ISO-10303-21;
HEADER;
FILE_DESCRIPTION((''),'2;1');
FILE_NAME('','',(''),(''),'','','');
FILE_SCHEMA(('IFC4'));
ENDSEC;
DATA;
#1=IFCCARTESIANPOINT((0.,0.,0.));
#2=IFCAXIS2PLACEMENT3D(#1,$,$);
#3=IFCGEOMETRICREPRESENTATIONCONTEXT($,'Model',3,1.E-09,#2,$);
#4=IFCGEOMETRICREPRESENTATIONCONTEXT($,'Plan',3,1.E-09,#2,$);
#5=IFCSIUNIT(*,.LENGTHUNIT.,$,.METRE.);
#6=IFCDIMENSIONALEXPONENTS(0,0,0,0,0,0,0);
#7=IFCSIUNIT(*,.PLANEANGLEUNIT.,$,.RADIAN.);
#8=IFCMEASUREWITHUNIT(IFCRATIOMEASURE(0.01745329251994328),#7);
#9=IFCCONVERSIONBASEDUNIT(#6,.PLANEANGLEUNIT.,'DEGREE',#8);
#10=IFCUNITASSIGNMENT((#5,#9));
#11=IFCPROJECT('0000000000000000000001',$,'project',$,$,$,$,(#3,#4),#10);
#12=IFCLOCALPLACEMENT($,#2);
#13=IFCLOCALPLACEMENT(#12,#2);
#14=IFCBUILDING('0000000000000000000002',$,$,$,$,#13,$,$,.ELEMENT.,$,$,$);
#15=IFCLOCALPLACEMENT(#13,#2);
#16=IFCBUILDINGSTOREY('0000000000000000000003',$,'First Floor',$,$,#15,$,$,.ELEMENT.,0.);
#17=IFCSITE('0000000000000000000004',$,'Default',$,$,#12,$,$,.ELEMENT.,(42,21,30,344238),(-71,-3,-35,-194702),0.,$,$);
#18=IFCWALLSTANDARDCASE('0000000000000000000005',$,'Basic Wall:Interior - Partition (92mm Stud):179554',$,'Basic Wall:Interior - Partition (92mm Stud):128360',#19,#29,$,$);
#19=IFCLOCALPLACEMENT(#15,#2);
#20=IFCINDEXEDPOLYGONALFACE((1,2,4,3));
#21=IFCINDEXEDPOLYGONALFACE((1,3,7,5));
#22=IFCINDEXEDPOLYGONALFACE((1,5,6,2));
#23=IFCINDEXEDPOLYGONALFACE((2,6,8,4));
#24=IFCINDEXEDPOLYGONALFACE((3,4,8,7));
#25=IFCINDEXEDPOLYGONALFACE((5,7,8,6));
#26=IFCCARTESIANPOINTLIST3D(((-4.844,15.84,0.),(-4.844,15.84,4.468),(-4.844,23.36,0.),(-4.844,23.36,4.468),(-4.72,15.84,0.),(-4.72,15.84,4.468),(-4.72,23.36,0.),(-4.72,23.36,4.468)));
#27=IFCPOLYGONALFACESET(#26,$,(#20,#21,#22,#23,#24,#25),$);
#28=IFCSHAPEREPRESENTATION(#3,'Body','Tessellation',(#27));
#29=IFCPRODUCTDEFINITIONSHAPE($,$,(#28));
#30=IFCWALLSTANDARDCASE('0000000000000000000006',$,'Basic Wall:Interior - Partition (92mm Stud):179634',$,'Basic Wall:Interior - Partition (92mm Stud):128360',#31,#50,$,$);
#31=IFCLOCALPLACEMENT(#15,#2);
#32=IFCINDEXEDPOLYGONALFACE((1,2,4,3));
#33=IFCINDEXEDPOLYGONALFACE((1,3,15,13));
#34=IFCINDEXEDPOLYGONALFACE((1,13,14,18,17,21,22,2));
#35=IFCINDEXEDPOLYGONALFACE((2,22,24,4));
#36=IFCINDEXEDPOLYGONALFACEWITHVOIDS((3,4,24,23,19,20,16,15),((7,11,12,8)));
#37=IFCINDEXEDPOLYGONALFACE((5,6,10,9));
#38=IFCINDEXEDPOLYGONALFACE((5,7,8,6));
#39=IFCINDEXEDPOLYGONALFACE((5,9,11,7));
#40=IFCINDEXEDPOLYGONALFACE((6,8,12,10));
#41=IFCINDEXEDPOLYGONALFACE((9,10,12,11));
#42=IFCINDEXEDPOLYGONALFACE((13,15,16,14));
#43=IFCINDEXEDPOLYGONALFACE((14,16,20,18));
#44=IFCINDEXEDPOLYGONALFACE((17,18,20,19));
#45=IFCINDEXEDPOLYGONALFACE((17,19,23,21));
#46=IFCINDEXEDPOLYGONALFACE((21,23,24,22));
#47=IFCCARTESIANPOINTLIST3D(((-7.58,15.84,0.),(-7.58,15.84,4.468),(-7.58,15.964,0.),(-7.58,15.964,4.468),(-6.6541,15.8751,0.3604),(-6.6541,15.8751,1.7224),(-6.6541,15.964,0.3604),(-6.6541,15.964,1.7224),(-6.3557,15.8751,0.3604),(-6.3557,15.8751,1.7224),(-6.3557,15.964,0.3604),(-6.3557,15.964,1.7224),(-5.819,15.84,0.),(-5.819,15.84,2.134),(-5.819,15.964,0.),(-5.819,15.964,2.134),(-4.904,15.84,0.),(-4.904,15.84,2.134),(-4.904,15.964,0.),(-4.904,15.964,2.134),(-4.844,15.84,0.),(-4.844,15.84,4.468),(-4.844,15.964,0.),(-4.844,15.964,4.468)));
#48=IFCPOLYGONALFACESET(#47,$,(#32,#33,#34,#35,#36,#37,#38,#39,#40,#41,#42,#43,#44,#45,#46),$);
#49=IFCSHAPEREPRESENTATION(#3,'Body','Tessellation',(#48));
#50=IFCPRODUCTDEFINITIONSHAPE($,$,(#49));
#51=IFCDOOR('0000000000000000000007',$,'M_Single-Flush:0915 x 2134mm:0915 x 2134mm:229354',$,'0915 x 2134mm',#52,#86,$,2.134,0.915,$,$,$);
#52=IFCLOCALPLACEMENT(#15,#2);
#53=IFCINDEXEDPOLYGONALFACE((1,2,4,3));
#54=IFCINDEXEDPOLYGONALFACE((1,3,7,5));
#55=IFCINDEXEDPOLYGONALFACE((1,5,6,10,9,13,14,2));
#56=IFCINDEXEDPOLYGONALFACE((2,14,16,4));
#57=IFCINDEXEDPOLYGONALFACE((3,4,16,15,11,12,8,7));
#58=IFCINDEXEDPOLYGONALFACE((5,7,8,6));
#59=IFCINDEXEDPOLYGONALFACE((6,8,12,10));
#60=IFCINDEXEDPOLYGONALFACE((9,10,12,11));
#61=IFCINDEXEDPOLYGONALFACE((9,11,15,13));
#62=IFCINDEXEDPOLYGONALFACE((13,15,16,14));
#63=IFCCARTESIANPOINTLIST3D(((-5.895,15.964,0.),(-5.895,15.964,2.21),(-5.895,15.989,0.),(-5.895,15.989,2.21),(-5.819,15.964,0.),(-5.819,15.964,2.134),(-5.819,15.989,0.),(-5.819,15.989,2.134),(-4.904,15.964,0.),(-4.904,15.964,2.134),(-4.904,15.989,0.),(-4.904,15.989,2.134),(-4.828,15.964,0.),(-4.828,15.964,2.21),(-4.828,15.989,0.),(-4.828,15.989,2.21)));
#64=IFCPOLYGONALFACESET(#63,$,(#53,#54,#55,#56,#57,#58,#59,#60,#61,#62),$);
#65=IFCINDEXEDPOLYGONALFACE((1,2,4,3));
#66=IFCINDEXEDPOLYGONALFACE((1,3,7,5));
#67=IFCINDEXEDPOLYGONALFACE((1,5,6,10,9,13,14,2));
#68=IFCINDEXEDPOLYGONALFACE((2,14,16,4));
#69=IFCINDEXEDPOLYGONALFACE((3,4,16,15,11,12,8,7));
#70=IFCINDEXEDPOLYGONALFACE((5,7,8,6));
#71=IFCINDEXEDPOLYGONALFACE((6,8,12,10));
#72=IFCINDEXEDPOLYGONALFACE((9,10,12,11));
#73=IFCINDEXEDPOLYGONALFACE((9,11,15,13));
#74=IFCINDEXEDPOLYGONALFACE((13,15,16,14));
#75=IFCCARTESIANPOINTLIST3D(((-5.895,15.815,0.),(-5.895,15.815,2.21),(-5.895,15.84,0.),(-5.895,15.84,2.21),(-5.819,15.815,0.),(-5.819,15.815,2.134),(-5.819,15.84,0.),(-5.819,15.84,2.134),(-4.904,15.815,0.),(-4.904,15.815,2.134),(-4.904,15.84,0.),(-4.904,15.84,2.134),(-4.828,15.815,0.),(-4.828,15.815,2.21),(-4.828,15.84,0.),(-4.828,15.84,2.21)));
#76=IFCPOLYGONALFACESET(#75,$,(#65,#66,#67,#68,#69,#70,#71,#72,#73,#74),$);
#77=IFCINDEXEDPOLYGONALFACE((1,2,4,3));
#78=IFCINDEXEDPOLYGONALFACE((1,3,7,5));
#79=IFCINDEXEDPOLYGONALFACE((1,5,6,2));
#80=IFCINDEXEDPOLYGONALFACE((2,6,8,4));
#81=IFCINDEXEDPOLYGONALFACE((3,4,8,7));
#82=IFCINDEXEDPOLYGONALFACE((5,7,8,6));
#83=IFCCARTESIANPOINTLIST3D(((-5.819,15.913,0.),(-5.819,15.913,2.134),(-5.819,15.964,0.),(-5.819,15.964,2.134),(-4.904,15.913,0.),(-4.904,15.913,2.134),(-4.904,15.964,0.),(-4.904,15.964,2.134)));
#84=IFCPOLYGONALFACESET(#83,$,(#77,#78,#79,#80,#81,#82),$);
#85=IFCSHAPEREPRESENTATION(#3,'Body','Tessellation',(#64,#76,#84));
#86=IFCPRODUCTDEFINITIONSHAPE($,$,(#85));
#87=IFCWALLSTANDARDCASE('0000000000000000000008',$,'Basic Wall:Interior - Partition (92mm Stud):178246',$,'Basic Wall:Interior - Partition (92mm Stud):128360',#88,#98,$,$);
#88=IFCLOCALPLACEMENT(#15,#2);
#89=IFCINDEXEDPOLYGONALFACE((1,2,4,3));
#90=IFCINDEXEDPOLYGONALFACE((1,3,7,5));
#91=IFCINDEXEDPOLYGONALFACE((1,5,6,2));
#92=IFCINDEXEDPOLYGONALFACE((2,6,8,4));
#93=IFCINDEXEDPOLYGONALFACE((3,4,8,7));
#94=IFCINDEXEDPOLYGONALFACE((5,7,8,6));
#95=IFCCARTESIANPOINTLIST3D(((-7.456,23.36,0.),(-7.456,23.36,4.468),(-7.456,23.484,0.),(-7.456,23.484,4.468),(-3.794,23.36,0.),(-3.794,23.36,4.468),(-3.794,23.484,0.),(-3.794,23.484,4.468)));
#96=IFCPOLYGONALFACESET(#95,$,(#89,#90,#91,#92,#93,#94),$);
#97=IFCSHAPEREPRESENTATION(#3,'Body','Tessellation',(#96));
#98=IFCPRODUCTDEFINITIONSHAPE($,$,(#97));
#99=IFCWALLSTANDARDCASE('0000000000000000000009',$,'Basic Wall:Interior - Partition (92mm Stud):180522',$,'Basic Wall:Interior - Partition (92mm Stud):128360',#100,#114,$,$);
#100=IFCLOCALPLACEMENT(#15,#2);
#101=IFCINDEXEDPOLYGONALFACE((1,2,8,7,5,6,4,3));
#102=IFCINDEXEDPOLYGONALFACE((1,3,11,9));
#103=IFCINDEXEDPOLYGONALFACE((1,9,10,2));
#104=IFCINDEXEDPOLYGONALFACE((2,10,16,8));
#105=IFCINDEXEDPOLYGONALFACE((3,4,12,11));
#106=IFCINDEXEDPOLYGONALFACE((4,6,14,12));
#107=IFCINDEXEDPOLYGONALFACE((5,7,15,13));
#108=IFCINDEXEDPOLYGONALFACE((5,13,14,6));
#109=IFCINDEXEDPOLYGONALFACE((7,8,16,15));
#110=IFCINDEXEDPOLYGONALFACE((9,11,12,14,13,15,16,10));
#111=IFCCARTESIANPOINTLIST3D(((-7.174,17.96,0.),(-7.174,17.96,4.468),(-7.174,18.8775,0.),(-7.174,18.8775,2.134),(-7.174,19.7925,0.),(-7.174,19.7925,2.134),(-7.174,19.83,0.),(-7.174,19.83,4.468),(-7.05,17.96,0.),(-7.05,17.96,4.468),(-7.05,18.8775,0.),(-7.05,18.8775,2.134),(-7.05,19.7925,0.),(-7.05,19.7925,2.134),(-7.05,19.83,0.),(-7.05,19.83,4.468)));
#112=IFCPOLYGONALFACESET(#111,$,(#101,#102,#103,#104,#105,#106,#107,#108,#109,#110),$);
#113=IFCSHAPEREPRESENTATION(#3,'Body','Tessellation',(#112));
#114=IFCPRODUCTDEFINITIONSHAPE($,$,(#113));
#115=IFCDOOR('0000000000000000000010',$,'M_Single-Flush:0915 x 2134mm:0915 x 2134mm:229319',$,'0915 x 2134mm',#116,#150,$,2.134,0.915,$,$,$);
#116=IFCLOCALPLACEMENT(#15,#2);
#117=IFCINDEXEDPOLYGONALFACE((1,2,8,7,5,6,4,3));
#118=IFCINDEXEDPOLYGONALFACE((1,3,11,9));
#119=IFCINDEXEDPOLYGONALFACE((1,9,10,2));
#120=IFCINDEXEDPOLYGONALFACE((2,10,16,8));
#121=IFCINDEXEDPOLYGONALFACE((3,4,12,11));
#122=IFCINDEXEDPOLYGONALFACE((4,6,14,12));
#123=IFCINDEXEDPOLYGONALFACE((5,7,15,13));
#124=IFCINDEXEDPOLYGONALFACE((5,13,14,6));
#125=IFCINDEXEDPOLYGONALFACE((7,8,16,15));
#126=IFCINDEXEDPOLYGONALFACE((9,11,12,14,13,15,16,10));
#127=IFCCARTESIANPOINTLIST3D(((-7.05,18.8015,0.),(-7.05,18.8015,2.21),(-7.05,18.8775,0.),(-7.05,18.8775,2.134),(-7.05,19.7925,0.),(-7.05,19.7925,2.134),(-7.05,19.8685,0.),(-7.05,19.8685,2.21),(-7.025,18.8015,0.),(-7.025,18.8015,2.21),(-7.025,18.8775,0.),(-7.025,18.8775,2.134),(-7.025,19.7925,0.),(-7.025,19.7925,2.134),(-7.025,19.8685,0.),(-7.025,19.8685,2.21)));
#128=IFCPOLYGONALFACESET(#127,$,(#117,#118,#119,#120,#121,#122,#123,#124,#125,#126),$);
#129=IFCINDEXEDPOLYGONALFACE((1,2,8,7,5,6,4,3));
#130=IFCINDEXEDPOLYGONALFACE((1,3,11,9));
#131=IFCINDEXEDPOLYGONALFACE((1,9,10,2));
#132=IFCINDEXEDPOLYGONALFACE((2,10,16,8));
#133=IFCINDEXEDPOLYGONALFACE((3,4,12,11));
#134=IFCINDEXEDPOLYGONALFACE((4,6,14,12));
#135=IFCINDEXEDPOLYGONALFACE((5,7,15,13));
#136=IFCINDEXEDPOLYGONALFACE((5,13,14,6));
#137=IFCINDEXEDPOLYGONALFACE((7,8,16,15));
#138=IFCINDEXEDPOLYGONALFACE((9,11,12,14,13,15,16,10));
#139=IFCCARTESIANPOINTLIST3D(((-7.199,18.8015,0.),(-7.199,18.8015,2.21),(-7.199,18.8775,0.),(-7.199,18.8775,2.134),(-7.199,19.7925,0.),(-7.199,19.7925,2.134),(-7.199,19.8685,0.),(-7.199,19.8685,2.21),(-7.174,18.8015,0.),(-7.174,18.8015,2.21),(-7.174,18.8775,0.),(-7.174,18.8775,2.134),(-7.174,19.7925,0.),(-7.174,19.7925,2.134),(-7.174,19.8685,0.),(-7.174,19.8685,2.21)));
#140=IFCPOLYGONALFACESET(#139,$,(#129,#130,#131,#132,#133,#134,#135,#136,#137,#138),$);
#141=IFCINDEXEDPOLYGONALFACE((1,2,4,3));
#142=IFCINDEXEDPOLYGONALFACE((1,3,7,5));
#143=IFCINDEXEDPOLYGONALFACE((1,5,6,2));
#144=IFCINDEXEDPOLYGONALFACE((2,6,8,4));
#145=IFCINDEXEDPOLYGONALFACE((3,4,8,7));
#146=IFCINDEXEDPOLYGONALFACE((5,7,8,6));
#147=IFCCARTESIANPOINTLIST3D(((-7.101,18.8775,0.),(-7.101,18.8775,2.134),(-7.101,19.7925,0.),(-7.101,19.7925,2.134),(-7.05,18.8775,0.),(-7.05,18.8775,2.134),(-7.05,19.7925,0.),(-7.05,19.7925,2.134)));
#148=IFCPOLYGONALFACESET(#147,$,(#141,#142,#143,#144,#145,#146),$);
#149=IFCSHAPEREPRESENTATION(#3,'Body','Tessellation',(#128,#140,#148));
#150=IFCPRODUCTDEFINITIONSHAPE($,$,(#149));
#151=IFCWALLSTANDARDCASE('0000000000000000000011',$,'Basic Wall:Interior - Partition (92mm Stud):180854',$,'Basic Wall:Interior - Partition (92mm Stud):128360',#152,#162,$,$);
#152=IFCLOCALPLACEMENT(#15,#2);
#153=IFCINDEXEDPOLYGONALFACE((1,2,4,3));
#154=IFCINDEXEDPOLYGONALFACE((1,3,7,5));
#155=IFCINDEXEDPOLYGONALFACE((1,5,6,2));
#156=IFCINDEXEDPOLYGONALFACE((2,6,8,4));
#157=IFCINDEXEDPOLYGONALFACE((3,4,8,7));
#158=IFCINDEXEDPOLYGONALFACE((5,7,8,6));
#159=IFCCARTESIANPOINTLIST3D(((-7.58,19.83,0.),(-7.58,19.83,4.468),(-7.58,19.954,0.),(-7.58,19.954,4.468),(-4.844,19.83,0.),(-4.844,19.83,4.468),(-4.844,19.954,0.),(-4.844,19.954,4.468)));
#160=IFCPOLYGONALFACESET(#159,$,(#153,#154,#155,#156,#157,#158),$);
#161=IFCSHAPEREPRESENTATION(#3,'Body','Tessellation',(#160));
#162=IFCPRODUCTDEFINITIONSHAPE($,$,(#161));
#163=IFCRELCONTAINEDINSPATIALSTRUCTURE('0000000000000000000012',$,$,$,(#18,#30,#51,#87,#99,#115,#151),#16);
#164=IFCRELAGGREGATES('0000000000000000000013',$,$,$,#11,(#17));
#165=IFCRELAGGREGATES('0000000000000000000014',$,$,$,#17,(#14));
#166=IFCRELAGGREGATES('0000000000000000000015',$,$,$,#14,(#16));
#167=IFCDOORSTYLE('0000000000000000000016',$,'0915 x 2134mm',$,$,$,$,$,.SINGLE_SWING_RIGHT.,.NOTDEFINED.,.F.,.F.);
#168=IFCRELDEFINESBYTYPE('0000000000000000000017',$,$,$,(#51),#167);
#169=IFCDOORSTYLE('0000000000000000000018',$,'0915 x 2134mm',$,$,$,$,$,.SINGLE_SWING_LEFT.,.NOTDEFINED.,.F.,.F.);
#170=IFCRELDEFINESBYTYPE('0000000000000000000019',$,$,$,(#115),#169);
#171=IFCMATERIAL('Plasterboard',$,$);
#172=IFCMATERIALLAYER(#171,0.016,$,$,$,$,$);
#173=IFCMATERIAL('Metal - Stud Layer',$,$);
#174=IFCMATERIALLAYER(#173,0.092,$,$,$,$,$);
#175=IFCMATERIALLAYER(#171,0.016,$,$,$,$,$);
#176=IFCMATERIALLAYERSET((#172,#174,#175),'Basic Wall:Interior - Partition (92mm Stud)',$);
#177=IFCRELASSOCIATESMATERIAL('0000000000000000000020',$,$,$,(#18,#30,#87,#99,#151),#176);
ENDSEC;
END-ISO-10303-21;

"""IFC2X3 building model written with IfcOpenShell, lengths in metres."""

from ifc_helpers import new_model, entity, si_unit, converted_unit, frame, frame_2d, origin, origin_2d_with_axis, place, context, project, spatial, polyline, rectangle, outline, extrude, source, transform, mapped, material, layer, layer_set, layer_usage, type_object, type_shapes, element, fill, save


model = new_model("IFC2X3")

# Units and contexts
model_context = context("Model", 3, precision=1e-09, world=origin())
plan_context = context("Plan", 3, precision=1e-09, world=origin())
ifc_project = project(units=[si_unit("LENGTHUNIT", "METRE"), converted_unit("PLANEANGLEUNIT", "DEGREE", entity("IfcRatioMeasure", 0.01745329251994328), si_unit("PLANEANGLEUNIT", "RADIAN"), dimensions=[0, 0, 0, 0, 0, 0, 0])], contexts=[model_context, plan_context])

# Site, building, storey
site_placement = place(None, origin())
site = spatial("IfcSite", under=ifc_project, at=site_placement, Name="Default", CompositionType="ELEMENT", RefLatitude=(42, 21, 30, 344238), RefLongitude=(-71, -3, -35, -194702), RefElevation=0.0)
building_placement = place(site_placement, origin())
building = spatial("IfcBuilding", under=site, at=building_placement, CompositionType="ELEMENT")
storey_placement = place(building_placement, origin())
storey = spatial("IfcBuildingStorey", under=building, at=storey_placement, Name="First Floor", CompositionType="ELEMENT", Elevation=0.0)

# Wall
ifc_material_1 = material(Name="Plasterboard")
ifc_layer_1 = layer(ifc_material_1, 0.016)
ifc_material_2 = material(Name="Metal - Stud Layer")
ifc_layer_2 = layer(ifc_material_2, 0.092)
ifc_layer_3 = layer(ifc_material_1, 0.016)
ifc_layer_set_1 = layer_set([ifc_layer_1, ifc_layer_2, ifc_layer_3], Name="Basic Wall:Interior - Partition (92mm Stud)")
ifc_layer_usage_1 = layer_usage(ifc_layer_set_1, "AXIS2", "NEGATIVE", 0.062)
wall_1_placement = place(storey_placement, frame((-4.782, 23.36, 0.0), z_axis=(0.0, 0.0, 1.0), x_axis=(0.0, -1.0, 0.0)))
element("IfcWallStandardCase", 1, at=wall_1_placement, inside=storey, material=ifc_layer_usage_1, Name="Basic Wall:Interior - Partition (92mm Stud):179554", ObjectType="Basic Wall:Interior - Partition (92mm Stud):128360", context=model_context, shape_type="SweptSolid", body=[
    extrude(rectangle(XDim=7.52, YDim=0.124, at=frame_2d((3.76, 0.0), x_axis=(-1.0, 0.0))), origin(), (0.0, 0.0, 1.0), 4.468),
])

# Wall, openings, door
wall_2_placement = place(storey_placement, frame((-4.844, 15.902, 0.0), z_axis=(0.0, 0.0, 1.0), x_axis=(-1.0, 0.0, 0.0)))
wall_2 = element("IfcWallStandardCase", 2, at=wall_2_placement, inside=storey, material=ifc_layer_usage_1, Name="Basic Wall:Interior - Partition (92mm Stud):179634", ObjectType="Basic Wall:Interior - Partition (92mm Stud):128360", context=model_context, shape_type="SweptSolid", body=[
    extrude(rectangle(XDim=2.736, YDim=0.124, at=frame_2d((1.368, 0.0), x_axis=(-1.0, 0.0))), origin(), (0.0, 0.0, 1.0), 4.468),
])
opening_1_placement = place(wall_2_placement, origin())
element("IfcOpeningElement", 3, at=opening_1_placement, cuts=wall_2, ObjectType="Opening", context=model_context, shape_type="SweptSolid", body=[
    extrude(rectangle(XDim=1.3621, YDim=0.2985, at=origin_2d_with_axis()), frame((1.6609, -0.1255, 1.0414), z_axis=(0.0, 1.0, 0.0), x_axis=(0.0, 0.0, -1.0)), (0.0, 0.0, 1.0), 0.1524),
])
opening_2_placement = place(wall_2_placement, frame((0.975, 0.062, 0.0)))
opening_2 = element("IfcOpeningElement", 4, at=opening_2_placement, cuts=wall_2, ObjectType="Opening", context=model_context, shape_type="SweptSolid", body=[
    extrude(rectangle(XDim=0.915, YDim=2.134, at=frame_2d((1.067, 0.4575), x_axis=(0.0, 1.0))), frame((0.0, 0.0, 0.0), z_axis=(0.0, -1.0, 0.0), x_axis=(0.0, 0.0, 1.0)), (0.0, 0.0, 1.0), 0.124),
])
door_style_1 = type_object("IfcDoorStyle", Name="0915 x 2134mm", ConstructionType="NOTDEFINED", OperationType="SINGLE_SWING_RIGHT", ParameterTakesPrecedence=False, Sizeable=False)
shared_shape_1 = source(origin(), model_context, "Body", "SweptSolid", [
    extrude(outline(polyline([(-0.5335, -1.124), (0.5335, -1.124), (0.5335, 1.086), (0.4575, 1.086), (0.4575, -1.048), (-0.4575, -1.048), (-0.4575, 1.086), (-0.5335, 1.086), (-0.5335, -1.124)])), frame((0.4575, 0.124, 1.086), z_axis=(0.0, 1.0, 0.0), x_axis=(1.0, 0.0, 0.0)), (0.0, 0.0, 1.0), 0.025),
    extrude(outline(polyline([(-1.124, -0.5335), (1.086, -0.5335), (1.086, -0.4575), (-1.048, -0.4575), (-1.048, 0.4575), (1.086, 0.4575), (1.086, 0.5335), (-1.124, 0.5335), (-1.124, -0.5335)])), frame((0.4575, -0.025, 1.086), z_axis=(0.0, 1.0, 0.0), x_axis=(0.0, 0.0, -1.0)), (0.0, 0.0, 1.0), 0.025),
    extrude(rectangle(XDim=0.051, YDim=0.915, at=origin_2d_with_axis()), frame((0.4575, 0.0985, 0.0), z_axis=(0.0, 0.0, 1.0), x_axis=(0.0, 1.0, 0.0)), (0.0, 0.0, 1.0), 2.134),
])
type_shapes(door_style_1, [shared_shape_1])
door_1_placement = place(opening_2_placement, frame((0.0, 0.0, 0.0), z_axis=(0.0, 0.0, 1.0), x_axis=(-1.0, 0.0, 0.0)))
door_1 = element("IfcDoor", 5, at=door_1_placement, inside=storey, type_object=door_style_1, Name="M_Single-Flush:0915 x 2134mm:0915 x 2134mm:229354", ObjectType="0915 x 2134mm", OverallHeight=2.134, OverallWidth=0.915, context=model_context, shape_type="MappedRepresentation", body=[
    mapped(shared_shape_1, transform((0.0, 0.0, 0.0), scale=1.0)),
])
fill(opening_2, door_1)

# Wall
wall_3_placement = place(storey_placement, frame((-3.794, 23.422, 0.0), z_axis=(0.0, 0.0, 1.0), x_axis=(-1.0, 0.0, 0.0)))
element("IfcWallStandardCase", 6, at=wall_3_placement, inside=storey, material=ifc_layer_usage_1, Name="Basic Wall:Interior - Partition (92mm Stud):178246", ObjectType="Basic Wall:Interior - Partition (92mm Stud):128360", context=model_context, shape_type="SweptSolid", body=[
    extrude(rectangle(XDim=3.662, YDim=0.124, at=frame_2d((1.831, 0.0), x_axis=(-1.0, 0.0))), origin(), (0.0, 0.0, 1.0), 4.468),
])

# Wall, opening, door
wall_4_placement = place(storey_placement, frame((-7.112, 19.83, 0.0), z_axis=(0.0, 0.0, 1.0), x_axis=(0.0, -1.0, 0.0)))
wall_4 = element("IfcWallStandardCase", 7, at=wall_4_placement, inside=storey, material=ifc_layer_usage_1, Name="Basic Wall:Interior - Partition (92mm Stud):180522", ObjectType="Basic Wall:Interior - Partition (92mm Stud):128360", context=model_context, shape_type="SweptSolid", body=[
    extrude(rectangle(XDim=1.87, YDim=0.124, at=frame_2d((0.935, 0.0), x_axis=(-1.0, 0.0))), origin(), (0.0, 0.0, 1.0), 4.468),
])
opening_3_placement = place(wall_4_placement, frame((0.0375, -0.062, 0.0)))
opening_3 = element("IfcOpeningElement", 8, at=opening_3_placement, cuts=wall_4, ObjectType="Opening", context=model_context, shape_type="SweptSolid", body=[
    extrude(rectangle(XDim=0.915, YDim=2.134, at=frame_2d((1.067, 0.4575), x_axis=(0.0, -1.0))), frame((0.0, 0.0, 0.0), z_axis=(0.0, 1.0, 0.0), x_axis=(0.0, 0.0, 1.0)), (0.0, 0.0, 1.0), 0.124),
])
door_style_2 = type_object("IfcDoorStyle", Name="0915 x 2134mm", ConstructionType="NOTDEFINED", OperationType="SINGLE_SWING_LEFT", ParameterTakesPrecedence=False, Sizeable=False)
shared_shape_2 = source(origin(), model_context, "Body", "SweptSolid", [
    extrude(outline(polyline([(-0.5335, -1.124), (0.5335, -1.124), (0.5335, 1.086), (0.4575, 1.086), (0.4575, -1.048), (-0.4575, -1.048), (-0.4575, 1.086), (-0.5335, 1.086), (-0.5335, -1.124)])), frame((0.4575, 0.149, 1.086), z_axis=(0.0, -1.0, 0.0), x_axis=(-1.0, 0.0, 0.0)), (0.0, 0.0, 1.0), 0.025),
    extrude(outline(polyline([(-1.124, -0.5335), (1.086, -0.5335), (1.086, -0.4575), (-1.048, -0.4575), (-1.048, 0.4575), (1.086, 0.4575), (1.086, 0.5335), (-1.124, 0.5335), (-1.124, -0.5335)])), frame((0.4575, 0.0, 1.086), z_axis=(0.0, -1.0, 0.0), x_axis=(0.0, 0.0, -1.0)), (0.0, 0.0, 1.0), 0.025),
    extrude(rectangle(XDim=0.915, YDim=0.051, at=origin_2d_with_axis()), frame((0.4575, 0.0985, 0.0)), (0.0, 0.0, 1.0), 2.134),
])
type_shapes(door_style_2, [shared_shape_2])
door_2_placement = place(opening_3_placement, origin())
door_2 = element("IfcDoor", 9, at=door_2_placement, inside=storey, type_object=door_style_2, Name="M_Single-Flush:0915 x 2134mm:0915 x 2134mm:229319", ObjectType="0915 x 2134mm", OverallHeight=2.134, OverallWidth=0.915, context=model_context, shape_type="MappedRepresentation", body=[
    mapped(shared_shape_2, transform((0.0, 0.0, 0.0), scale=1.0)),
])
fill(opening_3, door_2)

# Wall
wall_5_placement = place(storey_placement, frame((-4.844, 19.892, 0.0), z_axis=(0.0, 0.0, 1.0), x_axis=(-1.0, 0.0, 0.0)))
element("IfcWallStandardCase", 10, at=wall_5_placement, inside=storey, material=ifc_layer_usage_1, Name="Basic Wall:Interior - Partition (92mm Stud):180854", ObjectType="Basic Wall:Interior - Partition (92mm Stud):128360", context=model_context, shape_type="SweptSolid", body=[
    extrude(rectangle(XDim=2.736, YDim=0.124, at=frame_2d((1.368, 0.0), x_axis=(-1.0, 0.0))), origin(), (0.0, 0.0, 1.0), 4.468),
])

save(model, "model.ifc")
